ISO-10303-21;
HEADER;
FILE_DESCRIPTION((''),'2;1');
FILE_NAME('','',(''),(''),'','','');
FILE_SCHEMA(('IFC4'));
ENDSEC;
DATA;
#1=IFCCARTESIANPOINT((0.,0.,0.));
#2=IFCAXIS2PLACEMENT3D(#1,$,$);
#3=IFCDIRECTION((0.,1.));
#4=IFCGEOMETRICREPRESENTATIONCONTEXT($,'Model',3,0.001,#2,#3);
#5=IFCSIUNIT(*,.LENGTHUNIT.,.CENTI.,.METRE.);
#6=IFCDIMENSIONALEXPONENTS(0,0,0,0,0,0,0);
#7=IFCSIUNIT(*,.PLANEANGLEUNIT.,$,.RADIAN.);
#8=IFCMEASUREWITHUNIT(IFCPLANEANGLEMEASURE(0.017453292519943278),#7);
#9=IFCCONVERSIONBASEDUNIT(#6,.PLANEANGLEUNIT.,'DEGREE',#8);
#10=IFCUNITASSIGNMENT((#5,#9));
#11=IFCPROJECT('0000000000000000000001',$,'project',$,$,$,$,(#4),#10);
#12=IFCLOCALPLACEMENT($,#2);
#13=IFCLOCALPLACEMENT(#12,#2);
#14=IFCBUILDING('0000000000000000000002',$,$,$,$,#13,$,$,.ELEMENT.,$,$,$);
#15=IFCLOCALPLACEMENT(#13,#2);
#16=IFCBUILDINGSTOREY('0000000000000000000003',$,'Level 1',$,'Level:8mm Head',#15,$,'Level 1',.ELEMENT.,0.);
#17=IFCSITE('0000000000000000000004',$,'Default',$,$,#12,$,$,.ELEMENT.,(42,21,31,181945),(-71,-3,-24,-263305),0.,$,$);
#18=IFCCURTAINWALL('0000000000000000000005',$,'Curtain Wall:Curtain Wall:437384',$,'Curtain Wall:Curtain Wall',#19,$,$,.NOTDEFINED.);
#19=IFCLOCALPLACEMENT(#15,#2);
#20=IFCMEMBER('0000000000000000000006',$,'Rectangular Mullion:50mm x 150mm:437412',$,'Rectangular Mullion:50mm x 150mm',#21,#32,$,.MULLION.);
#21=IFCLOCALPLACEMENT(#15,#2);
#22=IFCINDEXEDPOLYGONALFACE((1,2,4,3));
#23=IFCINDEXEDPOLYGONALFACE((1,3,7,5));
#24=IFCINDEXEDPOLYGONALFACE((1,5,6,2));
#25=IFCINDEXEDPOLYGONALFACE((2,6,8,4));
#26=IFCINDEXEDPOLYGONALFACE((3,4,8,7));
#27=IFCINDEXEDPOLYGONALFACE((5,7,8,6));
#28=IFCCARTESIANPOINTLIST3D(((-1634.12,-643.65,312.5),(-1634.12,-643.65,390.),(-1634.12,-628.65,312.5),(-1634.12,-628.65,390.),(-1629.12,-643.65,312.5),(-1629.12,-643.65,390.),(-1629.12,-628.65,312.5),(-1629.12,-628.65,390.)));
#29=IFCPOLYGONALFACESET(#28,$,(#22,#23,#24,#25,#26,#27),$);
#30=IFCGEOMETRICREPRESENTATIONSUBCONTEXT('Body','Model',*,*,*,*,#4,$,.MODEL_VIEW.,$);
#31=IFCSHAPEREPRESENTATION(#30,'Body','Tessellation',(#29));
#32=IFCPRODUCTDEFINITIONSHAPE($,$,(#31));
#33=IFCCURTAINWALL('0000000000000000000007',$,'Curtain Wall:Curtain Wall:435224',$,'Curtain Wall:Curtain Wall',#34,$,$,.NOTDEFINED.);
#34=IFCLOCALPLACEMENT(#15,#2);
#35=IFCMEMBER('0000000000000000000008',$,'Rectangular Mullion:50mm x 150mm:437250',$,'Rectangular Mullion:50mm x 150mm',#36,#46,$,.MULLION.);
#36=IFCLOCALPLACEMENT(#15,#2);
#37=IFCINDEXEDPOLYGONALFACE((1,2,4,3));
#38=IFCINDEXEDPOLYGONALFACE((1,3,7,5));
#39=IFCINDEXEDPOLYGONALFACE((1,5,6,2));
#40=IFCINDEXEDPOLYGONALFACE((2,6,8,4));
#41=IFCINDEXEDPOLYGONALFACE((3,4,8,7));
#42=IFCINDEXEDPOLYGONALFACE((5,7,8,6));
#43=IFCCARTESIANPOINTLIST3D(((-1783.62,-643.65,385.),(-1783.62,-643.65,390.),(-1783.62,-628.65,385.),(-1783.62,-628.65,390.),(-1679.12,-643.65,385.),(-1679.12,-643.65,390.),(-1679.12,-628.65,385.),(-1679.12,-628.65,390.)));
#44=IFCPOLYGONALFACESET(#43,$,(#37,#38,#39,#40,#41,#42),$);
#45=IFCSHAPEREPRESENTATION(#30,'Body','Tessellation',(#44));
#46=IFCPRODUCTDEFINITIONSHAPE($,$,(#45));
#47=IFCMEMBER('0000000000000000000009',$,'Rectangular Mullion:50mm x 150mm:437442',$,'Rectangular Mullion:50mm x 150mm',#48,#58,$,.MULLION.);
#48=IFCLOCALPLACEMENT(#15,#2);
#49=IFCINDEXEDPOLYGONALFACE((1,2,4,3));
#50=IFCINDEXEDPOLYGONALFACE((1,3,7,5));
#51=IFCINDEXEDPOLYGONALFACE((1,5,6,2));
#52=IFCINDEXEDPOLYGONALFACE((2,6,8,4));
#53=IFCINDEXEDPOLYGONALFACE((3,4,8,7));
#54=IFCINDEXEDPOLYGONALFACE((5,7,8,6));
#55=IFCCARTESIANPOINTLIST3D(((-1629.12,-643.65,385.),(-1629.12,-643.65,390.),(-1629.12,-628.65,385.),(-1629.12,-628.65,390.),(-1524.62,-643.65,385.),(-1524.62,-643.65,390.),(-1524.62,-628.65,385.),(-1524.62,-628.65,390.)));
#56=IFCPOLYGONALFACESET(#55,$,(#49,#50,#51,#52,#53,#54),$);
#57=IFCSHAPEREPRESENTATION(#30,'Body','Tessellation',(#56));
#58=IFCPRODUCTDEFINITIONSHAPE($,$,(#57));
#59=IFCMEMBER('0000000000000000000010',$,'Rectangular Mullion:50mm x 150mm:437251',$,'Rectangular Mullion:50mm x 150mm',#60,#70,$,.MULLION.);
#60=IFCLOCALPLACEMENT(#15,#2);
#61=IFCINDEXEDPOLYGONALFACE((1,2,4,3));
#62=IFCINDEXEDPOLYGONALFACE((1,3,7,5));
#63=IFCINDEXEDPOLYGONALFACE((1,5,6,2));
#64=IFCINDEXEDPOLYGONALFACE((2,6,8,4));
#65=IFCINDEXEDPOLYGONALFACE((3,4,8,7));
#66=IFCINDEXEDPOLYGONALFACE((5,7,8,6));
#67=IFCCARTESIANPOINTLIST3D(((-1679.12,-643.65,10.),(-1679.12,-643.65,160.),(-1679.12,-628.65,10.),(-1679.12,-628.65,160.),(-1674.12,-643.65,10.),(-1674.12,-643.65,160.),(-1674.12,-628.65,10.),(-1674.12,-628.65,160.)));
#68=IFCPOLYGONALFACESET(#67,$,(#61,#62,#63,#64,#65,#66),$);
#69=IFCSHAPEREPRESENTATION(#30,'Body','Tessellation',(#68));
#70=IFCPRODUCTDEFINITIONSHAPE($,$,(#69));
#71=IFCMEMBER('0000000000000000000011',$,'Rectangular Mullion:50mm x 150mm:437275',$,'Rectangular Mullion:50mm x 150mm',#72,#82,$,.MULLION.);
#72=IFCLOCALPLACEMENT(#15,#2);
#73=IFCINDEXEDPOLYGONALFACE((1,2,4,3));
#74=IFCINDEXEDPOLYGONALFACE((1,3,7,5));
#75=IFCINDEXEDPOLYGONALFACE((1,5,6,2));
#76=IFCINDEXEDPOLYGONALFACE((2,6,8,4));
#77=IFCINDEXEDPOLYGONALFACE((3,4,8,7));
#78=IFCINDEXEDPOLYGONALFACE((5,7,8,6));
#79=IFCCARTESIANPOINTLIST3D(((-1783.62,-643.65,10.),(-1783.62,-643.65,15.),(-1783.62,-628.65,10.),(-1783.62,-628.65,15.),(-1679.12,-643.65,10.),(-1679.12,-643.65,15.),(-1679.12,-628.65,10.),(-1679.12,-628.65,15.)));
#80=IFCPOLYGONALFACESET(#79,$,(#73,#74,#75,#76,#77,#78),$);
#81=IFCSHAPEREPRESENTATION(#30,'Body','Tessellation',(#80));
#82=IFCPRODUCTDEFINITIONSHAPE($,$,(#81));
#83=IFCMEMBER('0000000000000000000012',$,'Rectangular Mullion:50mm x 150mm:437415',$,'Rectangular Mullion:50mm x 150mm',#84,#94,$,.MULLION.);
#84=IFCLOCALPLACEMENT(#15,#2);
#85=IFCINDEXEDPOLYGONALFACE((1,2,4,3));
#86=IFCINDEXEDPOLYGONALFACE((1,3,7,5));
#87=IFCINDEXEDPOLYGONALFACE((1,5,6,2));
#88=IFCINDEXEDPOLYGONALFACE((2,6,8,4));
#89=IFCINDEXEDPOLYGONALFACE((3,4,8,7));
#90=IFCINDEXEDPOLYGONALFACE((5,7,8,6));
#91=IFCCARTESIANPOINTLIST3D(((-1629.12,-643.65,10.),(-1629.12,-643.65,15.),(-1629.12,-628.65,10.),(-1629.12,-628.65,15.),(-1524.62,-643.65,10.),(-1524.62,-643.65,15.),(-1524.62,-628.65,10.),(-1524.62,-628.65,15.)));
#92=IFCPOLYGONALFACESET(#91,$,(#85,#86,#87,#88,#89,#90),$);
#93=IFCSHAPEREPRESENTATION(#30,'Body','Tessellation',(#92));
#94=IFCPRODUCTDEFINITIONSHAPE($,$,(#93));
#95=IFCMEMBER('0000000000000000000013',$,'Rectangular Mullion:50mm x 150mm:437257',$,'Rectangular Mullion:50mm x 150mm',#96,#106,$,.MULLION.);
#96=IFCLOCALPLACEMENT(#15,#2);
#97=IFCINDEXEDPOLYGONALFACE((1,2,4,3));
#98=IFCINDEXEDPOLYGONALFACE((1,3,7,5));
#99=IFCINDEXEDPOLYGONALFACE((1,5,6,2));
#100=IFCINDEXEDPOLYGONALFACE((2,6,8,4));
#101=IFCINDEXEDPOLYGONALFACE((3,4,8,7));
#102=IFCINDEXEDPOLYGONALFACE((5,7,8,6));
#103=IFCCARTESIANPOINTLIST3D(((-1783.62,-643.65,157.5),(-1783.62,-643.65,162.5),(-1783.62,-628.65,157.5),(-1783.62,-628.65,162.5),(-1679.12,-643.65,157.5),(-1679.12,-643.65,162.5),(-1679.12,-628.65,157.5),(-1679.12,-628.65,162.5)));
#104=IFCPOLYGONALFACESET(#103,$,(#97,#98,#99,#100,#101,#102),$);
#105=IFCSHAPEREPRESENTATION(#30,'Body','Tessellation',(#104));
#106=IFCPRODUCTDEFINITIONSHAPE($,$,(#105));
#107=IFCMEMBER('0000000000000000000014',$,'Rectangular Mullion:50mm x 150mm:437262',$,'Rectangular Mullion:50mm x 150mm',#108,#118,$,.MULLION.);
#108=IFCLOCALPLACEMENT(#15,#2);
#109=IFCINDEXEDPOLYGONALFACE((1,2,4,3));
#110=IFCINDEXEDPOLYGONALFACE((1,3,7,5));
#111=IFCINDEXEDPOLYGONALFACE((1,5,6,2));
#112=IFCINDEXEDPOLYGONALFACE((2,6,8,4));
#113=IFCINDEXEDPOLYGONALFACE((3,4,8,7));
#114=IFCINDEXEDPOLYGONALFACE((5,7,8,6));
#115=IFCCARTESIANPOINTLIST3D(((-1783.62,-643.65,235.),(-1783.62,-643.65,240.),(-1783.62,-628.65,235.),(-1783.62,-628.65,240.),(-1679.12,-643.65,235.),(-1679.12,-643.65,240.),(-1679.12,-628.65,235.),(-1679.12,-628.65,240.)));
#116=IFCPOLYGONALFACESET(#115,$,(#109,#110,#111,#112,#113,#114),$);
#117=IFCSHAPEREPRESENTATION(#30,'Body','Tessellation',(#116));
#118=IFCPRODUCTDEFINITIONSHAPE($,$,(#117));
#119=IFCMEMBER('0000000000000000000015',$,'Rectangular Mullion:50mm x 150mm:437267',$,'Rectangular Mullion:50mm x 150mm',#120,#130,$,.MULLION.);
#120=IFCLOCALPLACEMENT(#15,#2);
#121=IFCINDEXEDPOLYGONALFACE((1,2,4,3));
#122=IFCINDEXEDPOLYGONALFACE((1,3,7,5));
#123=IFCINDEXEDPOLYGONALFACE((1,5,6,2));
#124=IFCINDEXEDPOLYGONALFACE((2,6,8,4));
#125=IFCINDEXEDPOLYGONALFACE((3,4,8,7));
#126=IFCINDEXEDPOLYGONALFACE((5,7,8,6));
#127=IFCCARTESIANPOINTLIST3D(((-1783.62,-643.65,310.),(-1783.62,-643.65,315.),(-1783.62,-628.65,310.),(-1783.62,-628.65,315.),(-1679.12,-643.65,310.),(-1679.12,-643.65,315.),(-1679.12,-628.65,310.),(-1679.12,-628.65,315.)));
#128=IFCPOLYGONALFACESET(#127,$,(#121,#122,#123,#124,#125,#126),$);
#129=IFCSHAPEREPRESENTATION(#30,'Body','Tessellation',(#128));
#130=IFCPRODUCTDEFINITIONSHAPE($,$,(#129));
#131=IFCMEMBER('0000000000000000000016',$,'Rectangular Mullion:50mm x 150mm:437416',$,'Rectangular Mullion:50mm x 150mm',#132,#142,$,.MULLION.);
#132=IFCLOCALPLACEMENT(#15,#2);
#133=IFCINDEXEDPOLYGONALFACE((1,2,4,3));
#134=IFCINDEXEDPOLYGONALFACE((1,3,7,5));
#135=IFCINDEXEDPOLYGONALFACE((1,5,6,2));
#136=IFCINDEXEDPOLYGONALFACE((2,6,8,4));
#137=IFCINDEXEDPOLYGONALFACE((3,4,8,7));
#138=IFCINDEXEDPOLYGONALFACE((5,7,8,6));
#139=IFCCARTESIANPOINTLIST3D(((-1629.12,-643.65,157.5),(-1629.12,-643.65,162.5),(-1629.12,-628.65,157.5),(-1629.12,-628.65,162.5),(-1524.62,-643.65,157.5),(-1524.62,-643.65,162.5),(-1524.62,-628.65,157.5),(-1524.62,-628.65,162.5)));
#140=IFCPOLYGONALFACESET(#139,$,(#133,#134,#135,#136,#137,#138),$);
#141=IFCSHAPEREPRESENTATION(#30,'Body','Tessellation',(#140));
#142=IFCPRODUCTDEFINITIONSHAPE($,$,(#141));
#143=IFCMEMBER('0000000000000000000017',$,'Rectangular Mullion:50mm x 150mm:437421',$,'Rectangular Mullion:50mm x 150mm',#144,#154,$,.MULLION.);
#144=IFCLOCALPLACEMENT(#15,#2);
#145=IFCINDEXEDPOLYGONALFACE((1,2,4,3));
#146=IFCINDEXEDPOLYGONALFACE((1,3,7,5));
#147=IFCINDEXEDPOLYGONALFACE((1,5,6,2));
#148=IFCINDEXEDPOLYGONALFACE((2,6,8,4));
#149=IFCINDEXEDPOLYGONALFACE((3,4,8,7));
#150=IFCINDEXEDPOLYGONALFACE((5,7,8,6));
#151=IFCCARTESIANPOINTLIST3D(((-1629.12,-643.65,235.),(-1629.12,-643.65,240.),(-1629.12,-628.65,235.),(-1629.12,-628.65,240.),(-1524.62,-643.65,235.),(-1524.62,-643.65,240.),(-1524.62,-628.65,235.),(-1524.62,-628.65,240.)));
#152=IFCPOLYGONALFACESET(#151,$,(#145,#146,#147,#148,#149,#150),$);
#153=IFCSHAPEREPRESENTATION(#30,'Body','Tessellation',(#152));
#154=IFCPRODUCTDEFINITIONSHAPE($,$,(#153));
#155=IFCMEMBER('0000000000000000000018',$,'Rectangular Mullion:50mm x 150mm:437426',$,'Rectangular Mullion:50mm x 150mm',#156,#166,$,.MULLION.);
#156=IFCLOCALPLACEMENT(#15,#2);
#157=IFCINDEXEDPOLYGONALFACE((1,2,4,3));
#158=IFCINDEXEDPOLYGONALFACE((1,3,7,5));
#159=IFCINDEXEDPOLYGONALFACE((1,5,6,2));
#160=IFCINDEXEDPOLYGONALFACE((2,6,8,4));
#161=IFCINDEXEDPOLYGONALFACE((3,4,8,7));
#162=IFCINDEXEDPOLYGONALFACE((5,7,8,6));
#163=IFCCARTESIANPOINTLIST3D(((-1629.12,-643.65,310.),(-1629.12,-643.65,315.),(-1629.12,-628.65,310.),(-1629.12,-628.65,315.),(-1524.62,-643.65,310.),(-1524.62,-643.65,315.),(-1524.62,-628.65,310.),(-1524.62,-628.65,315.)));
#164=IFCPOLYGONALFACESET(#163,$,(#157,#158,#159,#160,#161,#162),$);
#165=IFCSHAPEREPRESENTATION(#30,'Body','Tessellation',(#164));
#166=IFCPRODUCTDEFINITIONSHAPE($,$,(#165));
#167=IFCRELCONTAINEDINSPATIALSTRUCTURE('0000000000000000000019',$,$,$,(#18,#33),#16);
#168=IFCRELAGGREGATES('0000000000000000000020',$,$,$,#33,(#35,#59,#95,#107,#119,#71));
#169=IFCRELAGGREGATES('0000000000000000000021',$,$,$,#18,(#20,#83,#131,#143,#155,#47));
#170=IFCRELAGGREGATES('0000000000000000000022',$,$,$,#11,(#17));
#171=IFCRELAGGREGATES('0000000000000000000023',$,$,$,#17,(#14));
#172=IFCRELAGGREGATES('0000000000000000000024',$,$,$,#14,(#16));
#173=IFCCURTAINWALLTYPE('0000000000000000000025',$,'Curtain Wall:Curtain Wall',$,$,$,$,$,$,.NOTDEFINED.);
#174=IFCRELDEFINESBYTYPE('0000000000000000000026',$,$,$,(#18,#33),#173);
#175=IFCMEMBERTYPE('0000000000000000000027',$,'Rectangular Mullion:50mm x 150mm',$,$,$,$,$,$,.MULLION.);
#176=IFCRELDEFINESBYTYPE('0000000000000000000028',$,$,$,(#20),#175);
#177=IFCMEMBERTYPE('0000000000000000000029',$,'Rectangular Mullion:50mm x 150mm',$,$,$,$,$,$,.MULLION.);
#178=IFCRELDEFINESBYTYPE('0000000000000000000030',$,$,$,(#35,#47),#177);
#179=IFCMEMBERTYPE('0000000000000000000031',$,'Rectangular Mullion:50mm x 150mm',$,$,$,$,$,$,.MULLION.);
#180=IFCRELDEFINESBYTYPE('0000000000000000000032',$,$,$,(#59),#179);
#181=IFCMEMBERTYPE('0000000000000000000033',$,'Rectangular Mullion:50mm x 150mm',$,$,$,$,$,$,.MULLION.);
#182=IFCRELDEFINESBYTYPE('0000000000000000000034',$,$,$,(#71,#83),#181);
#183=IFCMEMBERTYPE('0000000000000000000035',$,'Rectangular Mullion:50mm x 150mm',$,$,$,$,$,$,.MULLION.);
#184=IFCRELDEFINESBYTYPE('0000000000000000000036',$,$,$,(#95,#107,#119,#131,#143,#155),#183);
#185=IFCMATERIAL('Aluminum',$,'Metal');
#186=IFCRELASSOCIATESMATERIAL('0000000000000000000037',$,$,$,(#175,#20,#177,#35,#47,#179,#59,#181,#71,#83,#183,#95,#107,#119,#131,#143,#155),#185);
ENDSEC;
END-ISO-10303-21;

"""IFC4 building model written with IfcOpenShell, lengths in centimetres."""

from ifc_helpers import new_model, entity, si_unit, converted_unit, direction, frame, origin, place, context, subcontext, project, spatial, indexed_curve, outline, extrude, source, transform, mapped, material, type_object, type_shapes, element, aggregate, save


model = new_model("IFC4")

# Units and contexts
model_context = context("Model", 3, precision=0.001, world=origin(), true_north=direction((0.0, 1.0)))
body_context = subcontext(model_context, "Body", "Model", "MODEL_VIEW")
ifc_project = project(units=[si_unit("LENGTHUNIT", "METRE", prefix="CENTI"), converted_unit("PLANEANGLEUNIT", "DEGREE", entity("IfcPlaneAngleMeasure", 0.017453292519943278), si_unit("PLANEANGLEUNIT", "RADIAN"), dimensions=[0, 0, 0, 0, 0, 0, 0])], contexts=[model_context])

# Site, building, storey
site_placement = place(None, origin())
site = spatial("IfcSite", under=ifc_project, at=site_placement, Name="Default", CompositionType="ELEMENT", RefLatitude=(42, 21, 31, 181945), RefLongitude=(-71, -3, -24, -263305), RefElevation=0.0)
building_placement = place(site_placement, origin())
building = spatial("IfcBuilding", under=site, at=building_placement, CompositionType="ELEMENT")
storey_placement = place(building_placement, origin())
storey = spatial("IfcBuildingStorey", under=building, at=storey_placement, Name="Level 1", ObjectType="Level:8mm Head", LongName="Level 1", CompositionType="ELEMENT", Elevation=0.0)

# Curtain walls, members
curtain_wall_type = type_object("IfcCurtainWallType", Name="Curtain Wall:Curtain Wall", PredefinedType="NOTDEFINED")
curtain_wall_1_placement = place(storey_placement, origin())
curtain_wall_1 = element("IfcCurtainWall", 1, at=curtain_wall_1_placement, inside=storey, type_object=curtain_wall_type, Name="Curtain Wall:Curtain Wall:437384", ObjectType="Curtain Wall:Curtain Wall", PredefinedType="NOTDEFINED")
ifc_material_1 = material(Name="Aluminum", Category="Metal")
member_type_1 = type_object("IfcMemberType", Name="Rectangular Mullion:50mm x 150mm", PredefinedType="MULLION", material=ifc_material_1)
shared_shape_1 = source(origin(), body_context, "Body", "SweptSolid", [
    extrude(outline(indexed_curve([(-2.5, -7.5), (2.5, -7.5), (2.5, 7.5), (-2.5, 7.5), (-2.5, -7.5)], self_intersect=False)), frame((-2.5, 0.0, -77.5), z_axis=(0.0, 0.0, 1.0), x_axis=(-1.0, 0.0, 0.0)), (0.0, 0.0, 1.0), 77.5),
])
type_shapes(member_type_1, [shared_shape_1])
member_1_placement = place(curtain_wall_1_placement, frame((-1634.12, -636.15, 390.0), z_axis=(0.0, 0.0, 1.0), x_axis=(-1.0, 0.0, 0.0)))
member_1 = element("IfcMember", 2, at=member_1_placement, type_object=member_type_1, material=ifc_material_1, Name="Rectangular Mullion:50mm x 150mm:437412", ObjectType="Rectangular Mullion:50mm x 150mm", PredefinedType="MULLION", context=body_context, shape_type="MappedRepresentation", body=[
    mapped(shared_shape_1, transform((0.0, 0.0, 0.0), scale=1.0)),
])
curtain_wall_2_placement = place(storey_placement, origin())
curtain_wall_2 = element("IfcCurtainWall", 3, at=curtain_wall_2_placement, inside=storey, type_object=curtain_wall_type, Name="Curtain Wall:Curtain Wall:435224", ObjectType="Curtain Wall:Curtain Wall", PredefinedType="NOTDEFINED")
member_type_2 = type_object("IfcMemberType", Name="Rectangular Mullion:50mm x 150mm", PredefinedType="MULLION", material=ifc_material_1)
shared_shape_2 = source(origin(), body_context, "Body", "SweptSolid", [
    extrude(outline(indexed_curve([(-2.5, -7.5), (2.5, -7.5), (2.5, 7.5), (-2.5, 7.5), (-2.5, -7.5)], self_intersect=False)), frame((-2.5, 0.0, -104.5), z_axis=(0.0, 0.0, 1.0), x_axis=(-1.0, 0.0, 0.0)), (0.0, 0.0, 1.0), 104.5),
])
type_shapes(member_type_2, [shared_shape_2])
member_2_placement = place(curtain_wall_2_placement, frame((-1679.12, -636.15, 390.0), z_axis=(1.0, 0.0, 0.0), x_axis=(0.0, 0.0, 1.0)))
member_2 = element("IfcMember", 4, at=member_2_placement, type_object=member_type_2, material=ifc_material_1, Name="Rectangular Mullion:50mm x 150mm:437250", ObjectType="Rectangular Mullion:50mm x 150mm", PredefinedType="MULLION", context=body_context, shape_type="MappedRepresentation", body=[
    mapped(shared_shape_2, transform((0.0, 0.0, 0.0), scale=1.0)),
])

# Members
member_3_placement = place(curtain_wall_1_placement, frame((-1524.62, -636.15, 390.0), z_axis=(1.0, 0.0, 0.0), x_axis=(0.0, 0.0, 1.0)))
member_3 = element("IfcMember", 5, at=member_3_placement, type_object=member_type_2, material=ifc_material_1, Name="Rectangular Mullion:50mm x 150mm:437442", ObjectType="Rectangular Mullion:50mm x 150mm", PredefinedType="MULLION", context=body_context, shape_type="MappedRepresentation", body=[
    mapped(shared_shape_2, transform((0.0, 0.0, 0.0), scale=1.0)),
])
member_type_3 = type_object("IfcMemberType", Name="Rectangular Mullion:50mm x 150mm", PredefinedType="MULLION", material=ifc_material_1)
shared_shape_3 = source(origin(), body_context, "Body", "SweptSolid", [
    extrude(outline(indexed_curve([(-2.5, -7.5), (2.5, -7.5), (2.5, 7.5), (-2.5, 7.5), (-2.5, -7.5)], self_intersect=False)), frame((-2.5, 0.0, -150.0), z_axis=(0.0, 0.0, 1.0), x_axis=(-1.0, 0.0, 0.0)), (0.0, 0.0, 1.0), 150.0),
])
type_shapes(member_type_3, [shared_shape_3])
member_4_placement = place(curtain_wall_2_placement, frame((-1674.12, -636.15, 10.0), z_axis=(0.0, 0.0, -1.0), x_axis=(1.0, 0.0, 0.0)))
member_4 = element("IfcMember", 6, at=member_4_placement, type_object=member_type_3, material=ifc_material_1, Name="Rectangular Mullion:50mm x 150mm:437251", ObjectType="Rectangular Mullion:50mm x 150mm", PredefinedType="MULLION", context=body_context, shape_type="MappedRepresentation", body=[
    mapped(shared_shape_3, transform((0.0, 0.0, 0.0), scale=1.0)),
])
member_type_4 = type_object("IfcMemberType", Name="Rectangular Mullion:50mm x 150mm", PredefinedType="MULLION", material=ifc_material_1)
shared_shape_4 = source(origin(), body_context, "Body", "SweptSolid", [
    extrude(outline(indexed_curve([(-2.5, -7.5), (2.5, -7.5), (2.5, 7.5), (-2.5, 7.5), (-2.5, -7.5)], self_intersect=False)), frame((-2.5, 0.0, -104.5), z_axis=(0.0, 0.0, 1.0), x_axis=(-1.0, 0.0, 0.0)), (0.0, 0.0, 1.0), 104.5),
])
type_shapes(member_type_4, [shared_shape_4])
member_5_placement = place(curtain_wall_2_placement, frame((-1783.62, -636.15, 10.0), z_axis=(-1.0, 0.0, 0.0), x_axis=(0.0, 0.0, -1.0)))
member_5 = element("IfcMember", 7, at=member_5_placement, type_object=member_type_4, material=ifc_material_1, Name="Rectangular Mullion:50mm x 150mm:437275", ObjectType="Rectangular Mullion:50mm x 150mm", PredefinedType="MULLION", context=body_context, shape_type="MappedRepresentation", body=[
    mapped(shared_shape_4, transform((0.0, 0.0, 0.0), scale=1.0)),
])
member_6_placement = place(curtain_wall_1_placement, frame((-1629.12, -636.15, 10.0), z_axis=(-1.0, 0.0, 0.0), x_axis=(0.0, 0.0, -1.0)))
member_6 = element("IfcMember", 8, at=member_6_placement, type_object=member_type_4, material=ifc_material_1, Name="Rectangular Mullion:50mm x 150mm:437415", ObjectType="Rectangular Mullion:50mm x 150mm", PredefinedType="MULLION", context=body_context, shape_type="MappedRepresentation", body=[
    mapped(shared_shape_4, transform((0.0, 0.0, 0.0), scale=1.0)),
])
member_type_5 = type_object("IfcMemberType", Name="Rectangular Mullion:50mm x 150mm", PredefinedType="MULLION", material=ifc_material_1)
shared_shape_5 = source(origin(), body_context, "Body", "SweptSolid", [
    extrude(outline(indexed_curve([(-2.5, -7.5), (2.5, -7.5), (2.5, 7.5), (-2.5, 7.5), (-2.5, -7.5)], self_intersect=False)), frame((0.0, 0.0, -104.5), z_axis=(0.0, 0.0, 1.0), x_axis=(-1.0, 0.0, 0.0)), (0.0, 0.0, 1.0), 104.5),
])
type_shapes(member_type_5, [shared_shape_5])
member_7_placement = place(curtain_wall_2_placement, frame((-1679.12, -636.15, 160.0), z_axis=(1.0, 0.0, 0.0), x_axis=(0.0, 0.0, 1.0)))
member_7 = element("IfcMember", 9, at=member_7_placement, type_object=member_type_5, material=ifc_material_1, Name="Rectangular Mullion:50mm x 150mm:437257", ObjectType="Rectangular Mullion:50mm x 150mm", PredefinedType="MULLION", context=body_context, shape_type="MappedRepresentation", body=[
    mapped(shared_shape_5, transform((0.0, 0.0, 0.0), scale=1.0)),
])
member_8_placement = place(curtain_wall_2_placement, frame((-1679.12, -636.15, 237.5), z_axis=(1.0, 0.0, 0.0), x_axis=(0.0, 0.0, 1.0)))
member_8 = element("IfcMember", 10, at=member_8_placement, type_object=member_type_5, material=ifc_material_1, Name="Rectangular Mullion:50mm x 150mm:437262", ObjectType="Rectangular Mullion:50mm x 150mm", PredefinedType="MULLION", context=body_context, shape_type="MappedRepresentation", body=[
    mapped(shared_shape_5, transform((0.0, 0.0, 0.0), scale=1.0)),
])
member_9_placement = place(curtain_wall_2_placement, frame((-1679.12, -636.15, 312.5), z_axis=(1.0, 0.0, 0.0), x_axis=(0.0, 0.0, 1.0)))
member_9 = element("IfcMember", 11, at=member_9_placement, type_object=member_type_5, material=ifc_material_1, Name="Rectangular Mullion:50mm x 150mm:437267", ObjectType="Rectangular Mullion:50mm x 150mm", PredefinedType="MULLION", context=body_context, shape_type="MappedRepresentation", body=[
    mapped(shared_shape_5, transform((0.0, 0.0, 0.0), scale=1.0)),
])
member_10_placement = place(curtain_wall_1_placement, frame((-1524.62, -636.15, 160.0), z_axis=(1.0, 0.0, 0.0), x_axis=(0.0, 0.0, 1.0)))
member_10 = element("IfcMember", 12, at=member_10_placement, type_object=member_type_5, material=ifc_material_1, Name="Rectangular Mullion:50mm x 150mm:437416", ObjectType="Rectangular Mullion:50mm x 150mm", PredefinedType="MULLION", context=body_context, shape_type="MappedRepresentation", body=[
    mapped(shared_shape_5, transform((0.0, 0.0, 0.0), scale=1.0)),
])
member_11_placement = place(curtain_wall_1_placement, frame((-1524.62, -636.15, 237.5), z_axis=(1.0, 0.0, 0.0), x_axis=(0.0, 0.0, 1.0)))
member_11 = element("IfcMember", 13, at=member_11_placement, type_object=member_type_5, material=ifc_material_1, Name="Rectangular Mullion:50mm x 150mm:437421", ObjectType="Rectangular Mullion:50mm x 150mm", PredefinedType="MULLION", context=body_context, shape_type="MappedRepresentation", body=[
    mapped(shared_shape_5, transform((0.0, 0.0, 0.0), scale=1.0)),
])
member_12_placement = place(curtain_wall_1_placement, frame((-1524.62, -636.15, 312.5), z_axis=(1.0, 0.0, 0.0), x_axis=(0.0, 0.0, 1.0)))
member_12 = element("IfcMember", 14, at=member_12_placement, type_object=member_type_5, material=ifc_material_1, Name="Rectangular Mullion:50mm x 150mm:437426", ObjectType="Rectangular Mullion:50mm x 150mm", PredefinedType="MULLION", context=body_context, shape_type="MappedRepresentation", body=[
    mapped(shared_shape_5, transform((0.0, 0.0, 0.0), scale=1.0)),
])

aggregate(curtain_wall_2, [member_2, member_4, member_7, member_8, member_9, member_5])
aggregate(curtain_wall_1, [member_1, member_6, member_10, member_11, member_12, member_3])

save(model, "model.ifc")
